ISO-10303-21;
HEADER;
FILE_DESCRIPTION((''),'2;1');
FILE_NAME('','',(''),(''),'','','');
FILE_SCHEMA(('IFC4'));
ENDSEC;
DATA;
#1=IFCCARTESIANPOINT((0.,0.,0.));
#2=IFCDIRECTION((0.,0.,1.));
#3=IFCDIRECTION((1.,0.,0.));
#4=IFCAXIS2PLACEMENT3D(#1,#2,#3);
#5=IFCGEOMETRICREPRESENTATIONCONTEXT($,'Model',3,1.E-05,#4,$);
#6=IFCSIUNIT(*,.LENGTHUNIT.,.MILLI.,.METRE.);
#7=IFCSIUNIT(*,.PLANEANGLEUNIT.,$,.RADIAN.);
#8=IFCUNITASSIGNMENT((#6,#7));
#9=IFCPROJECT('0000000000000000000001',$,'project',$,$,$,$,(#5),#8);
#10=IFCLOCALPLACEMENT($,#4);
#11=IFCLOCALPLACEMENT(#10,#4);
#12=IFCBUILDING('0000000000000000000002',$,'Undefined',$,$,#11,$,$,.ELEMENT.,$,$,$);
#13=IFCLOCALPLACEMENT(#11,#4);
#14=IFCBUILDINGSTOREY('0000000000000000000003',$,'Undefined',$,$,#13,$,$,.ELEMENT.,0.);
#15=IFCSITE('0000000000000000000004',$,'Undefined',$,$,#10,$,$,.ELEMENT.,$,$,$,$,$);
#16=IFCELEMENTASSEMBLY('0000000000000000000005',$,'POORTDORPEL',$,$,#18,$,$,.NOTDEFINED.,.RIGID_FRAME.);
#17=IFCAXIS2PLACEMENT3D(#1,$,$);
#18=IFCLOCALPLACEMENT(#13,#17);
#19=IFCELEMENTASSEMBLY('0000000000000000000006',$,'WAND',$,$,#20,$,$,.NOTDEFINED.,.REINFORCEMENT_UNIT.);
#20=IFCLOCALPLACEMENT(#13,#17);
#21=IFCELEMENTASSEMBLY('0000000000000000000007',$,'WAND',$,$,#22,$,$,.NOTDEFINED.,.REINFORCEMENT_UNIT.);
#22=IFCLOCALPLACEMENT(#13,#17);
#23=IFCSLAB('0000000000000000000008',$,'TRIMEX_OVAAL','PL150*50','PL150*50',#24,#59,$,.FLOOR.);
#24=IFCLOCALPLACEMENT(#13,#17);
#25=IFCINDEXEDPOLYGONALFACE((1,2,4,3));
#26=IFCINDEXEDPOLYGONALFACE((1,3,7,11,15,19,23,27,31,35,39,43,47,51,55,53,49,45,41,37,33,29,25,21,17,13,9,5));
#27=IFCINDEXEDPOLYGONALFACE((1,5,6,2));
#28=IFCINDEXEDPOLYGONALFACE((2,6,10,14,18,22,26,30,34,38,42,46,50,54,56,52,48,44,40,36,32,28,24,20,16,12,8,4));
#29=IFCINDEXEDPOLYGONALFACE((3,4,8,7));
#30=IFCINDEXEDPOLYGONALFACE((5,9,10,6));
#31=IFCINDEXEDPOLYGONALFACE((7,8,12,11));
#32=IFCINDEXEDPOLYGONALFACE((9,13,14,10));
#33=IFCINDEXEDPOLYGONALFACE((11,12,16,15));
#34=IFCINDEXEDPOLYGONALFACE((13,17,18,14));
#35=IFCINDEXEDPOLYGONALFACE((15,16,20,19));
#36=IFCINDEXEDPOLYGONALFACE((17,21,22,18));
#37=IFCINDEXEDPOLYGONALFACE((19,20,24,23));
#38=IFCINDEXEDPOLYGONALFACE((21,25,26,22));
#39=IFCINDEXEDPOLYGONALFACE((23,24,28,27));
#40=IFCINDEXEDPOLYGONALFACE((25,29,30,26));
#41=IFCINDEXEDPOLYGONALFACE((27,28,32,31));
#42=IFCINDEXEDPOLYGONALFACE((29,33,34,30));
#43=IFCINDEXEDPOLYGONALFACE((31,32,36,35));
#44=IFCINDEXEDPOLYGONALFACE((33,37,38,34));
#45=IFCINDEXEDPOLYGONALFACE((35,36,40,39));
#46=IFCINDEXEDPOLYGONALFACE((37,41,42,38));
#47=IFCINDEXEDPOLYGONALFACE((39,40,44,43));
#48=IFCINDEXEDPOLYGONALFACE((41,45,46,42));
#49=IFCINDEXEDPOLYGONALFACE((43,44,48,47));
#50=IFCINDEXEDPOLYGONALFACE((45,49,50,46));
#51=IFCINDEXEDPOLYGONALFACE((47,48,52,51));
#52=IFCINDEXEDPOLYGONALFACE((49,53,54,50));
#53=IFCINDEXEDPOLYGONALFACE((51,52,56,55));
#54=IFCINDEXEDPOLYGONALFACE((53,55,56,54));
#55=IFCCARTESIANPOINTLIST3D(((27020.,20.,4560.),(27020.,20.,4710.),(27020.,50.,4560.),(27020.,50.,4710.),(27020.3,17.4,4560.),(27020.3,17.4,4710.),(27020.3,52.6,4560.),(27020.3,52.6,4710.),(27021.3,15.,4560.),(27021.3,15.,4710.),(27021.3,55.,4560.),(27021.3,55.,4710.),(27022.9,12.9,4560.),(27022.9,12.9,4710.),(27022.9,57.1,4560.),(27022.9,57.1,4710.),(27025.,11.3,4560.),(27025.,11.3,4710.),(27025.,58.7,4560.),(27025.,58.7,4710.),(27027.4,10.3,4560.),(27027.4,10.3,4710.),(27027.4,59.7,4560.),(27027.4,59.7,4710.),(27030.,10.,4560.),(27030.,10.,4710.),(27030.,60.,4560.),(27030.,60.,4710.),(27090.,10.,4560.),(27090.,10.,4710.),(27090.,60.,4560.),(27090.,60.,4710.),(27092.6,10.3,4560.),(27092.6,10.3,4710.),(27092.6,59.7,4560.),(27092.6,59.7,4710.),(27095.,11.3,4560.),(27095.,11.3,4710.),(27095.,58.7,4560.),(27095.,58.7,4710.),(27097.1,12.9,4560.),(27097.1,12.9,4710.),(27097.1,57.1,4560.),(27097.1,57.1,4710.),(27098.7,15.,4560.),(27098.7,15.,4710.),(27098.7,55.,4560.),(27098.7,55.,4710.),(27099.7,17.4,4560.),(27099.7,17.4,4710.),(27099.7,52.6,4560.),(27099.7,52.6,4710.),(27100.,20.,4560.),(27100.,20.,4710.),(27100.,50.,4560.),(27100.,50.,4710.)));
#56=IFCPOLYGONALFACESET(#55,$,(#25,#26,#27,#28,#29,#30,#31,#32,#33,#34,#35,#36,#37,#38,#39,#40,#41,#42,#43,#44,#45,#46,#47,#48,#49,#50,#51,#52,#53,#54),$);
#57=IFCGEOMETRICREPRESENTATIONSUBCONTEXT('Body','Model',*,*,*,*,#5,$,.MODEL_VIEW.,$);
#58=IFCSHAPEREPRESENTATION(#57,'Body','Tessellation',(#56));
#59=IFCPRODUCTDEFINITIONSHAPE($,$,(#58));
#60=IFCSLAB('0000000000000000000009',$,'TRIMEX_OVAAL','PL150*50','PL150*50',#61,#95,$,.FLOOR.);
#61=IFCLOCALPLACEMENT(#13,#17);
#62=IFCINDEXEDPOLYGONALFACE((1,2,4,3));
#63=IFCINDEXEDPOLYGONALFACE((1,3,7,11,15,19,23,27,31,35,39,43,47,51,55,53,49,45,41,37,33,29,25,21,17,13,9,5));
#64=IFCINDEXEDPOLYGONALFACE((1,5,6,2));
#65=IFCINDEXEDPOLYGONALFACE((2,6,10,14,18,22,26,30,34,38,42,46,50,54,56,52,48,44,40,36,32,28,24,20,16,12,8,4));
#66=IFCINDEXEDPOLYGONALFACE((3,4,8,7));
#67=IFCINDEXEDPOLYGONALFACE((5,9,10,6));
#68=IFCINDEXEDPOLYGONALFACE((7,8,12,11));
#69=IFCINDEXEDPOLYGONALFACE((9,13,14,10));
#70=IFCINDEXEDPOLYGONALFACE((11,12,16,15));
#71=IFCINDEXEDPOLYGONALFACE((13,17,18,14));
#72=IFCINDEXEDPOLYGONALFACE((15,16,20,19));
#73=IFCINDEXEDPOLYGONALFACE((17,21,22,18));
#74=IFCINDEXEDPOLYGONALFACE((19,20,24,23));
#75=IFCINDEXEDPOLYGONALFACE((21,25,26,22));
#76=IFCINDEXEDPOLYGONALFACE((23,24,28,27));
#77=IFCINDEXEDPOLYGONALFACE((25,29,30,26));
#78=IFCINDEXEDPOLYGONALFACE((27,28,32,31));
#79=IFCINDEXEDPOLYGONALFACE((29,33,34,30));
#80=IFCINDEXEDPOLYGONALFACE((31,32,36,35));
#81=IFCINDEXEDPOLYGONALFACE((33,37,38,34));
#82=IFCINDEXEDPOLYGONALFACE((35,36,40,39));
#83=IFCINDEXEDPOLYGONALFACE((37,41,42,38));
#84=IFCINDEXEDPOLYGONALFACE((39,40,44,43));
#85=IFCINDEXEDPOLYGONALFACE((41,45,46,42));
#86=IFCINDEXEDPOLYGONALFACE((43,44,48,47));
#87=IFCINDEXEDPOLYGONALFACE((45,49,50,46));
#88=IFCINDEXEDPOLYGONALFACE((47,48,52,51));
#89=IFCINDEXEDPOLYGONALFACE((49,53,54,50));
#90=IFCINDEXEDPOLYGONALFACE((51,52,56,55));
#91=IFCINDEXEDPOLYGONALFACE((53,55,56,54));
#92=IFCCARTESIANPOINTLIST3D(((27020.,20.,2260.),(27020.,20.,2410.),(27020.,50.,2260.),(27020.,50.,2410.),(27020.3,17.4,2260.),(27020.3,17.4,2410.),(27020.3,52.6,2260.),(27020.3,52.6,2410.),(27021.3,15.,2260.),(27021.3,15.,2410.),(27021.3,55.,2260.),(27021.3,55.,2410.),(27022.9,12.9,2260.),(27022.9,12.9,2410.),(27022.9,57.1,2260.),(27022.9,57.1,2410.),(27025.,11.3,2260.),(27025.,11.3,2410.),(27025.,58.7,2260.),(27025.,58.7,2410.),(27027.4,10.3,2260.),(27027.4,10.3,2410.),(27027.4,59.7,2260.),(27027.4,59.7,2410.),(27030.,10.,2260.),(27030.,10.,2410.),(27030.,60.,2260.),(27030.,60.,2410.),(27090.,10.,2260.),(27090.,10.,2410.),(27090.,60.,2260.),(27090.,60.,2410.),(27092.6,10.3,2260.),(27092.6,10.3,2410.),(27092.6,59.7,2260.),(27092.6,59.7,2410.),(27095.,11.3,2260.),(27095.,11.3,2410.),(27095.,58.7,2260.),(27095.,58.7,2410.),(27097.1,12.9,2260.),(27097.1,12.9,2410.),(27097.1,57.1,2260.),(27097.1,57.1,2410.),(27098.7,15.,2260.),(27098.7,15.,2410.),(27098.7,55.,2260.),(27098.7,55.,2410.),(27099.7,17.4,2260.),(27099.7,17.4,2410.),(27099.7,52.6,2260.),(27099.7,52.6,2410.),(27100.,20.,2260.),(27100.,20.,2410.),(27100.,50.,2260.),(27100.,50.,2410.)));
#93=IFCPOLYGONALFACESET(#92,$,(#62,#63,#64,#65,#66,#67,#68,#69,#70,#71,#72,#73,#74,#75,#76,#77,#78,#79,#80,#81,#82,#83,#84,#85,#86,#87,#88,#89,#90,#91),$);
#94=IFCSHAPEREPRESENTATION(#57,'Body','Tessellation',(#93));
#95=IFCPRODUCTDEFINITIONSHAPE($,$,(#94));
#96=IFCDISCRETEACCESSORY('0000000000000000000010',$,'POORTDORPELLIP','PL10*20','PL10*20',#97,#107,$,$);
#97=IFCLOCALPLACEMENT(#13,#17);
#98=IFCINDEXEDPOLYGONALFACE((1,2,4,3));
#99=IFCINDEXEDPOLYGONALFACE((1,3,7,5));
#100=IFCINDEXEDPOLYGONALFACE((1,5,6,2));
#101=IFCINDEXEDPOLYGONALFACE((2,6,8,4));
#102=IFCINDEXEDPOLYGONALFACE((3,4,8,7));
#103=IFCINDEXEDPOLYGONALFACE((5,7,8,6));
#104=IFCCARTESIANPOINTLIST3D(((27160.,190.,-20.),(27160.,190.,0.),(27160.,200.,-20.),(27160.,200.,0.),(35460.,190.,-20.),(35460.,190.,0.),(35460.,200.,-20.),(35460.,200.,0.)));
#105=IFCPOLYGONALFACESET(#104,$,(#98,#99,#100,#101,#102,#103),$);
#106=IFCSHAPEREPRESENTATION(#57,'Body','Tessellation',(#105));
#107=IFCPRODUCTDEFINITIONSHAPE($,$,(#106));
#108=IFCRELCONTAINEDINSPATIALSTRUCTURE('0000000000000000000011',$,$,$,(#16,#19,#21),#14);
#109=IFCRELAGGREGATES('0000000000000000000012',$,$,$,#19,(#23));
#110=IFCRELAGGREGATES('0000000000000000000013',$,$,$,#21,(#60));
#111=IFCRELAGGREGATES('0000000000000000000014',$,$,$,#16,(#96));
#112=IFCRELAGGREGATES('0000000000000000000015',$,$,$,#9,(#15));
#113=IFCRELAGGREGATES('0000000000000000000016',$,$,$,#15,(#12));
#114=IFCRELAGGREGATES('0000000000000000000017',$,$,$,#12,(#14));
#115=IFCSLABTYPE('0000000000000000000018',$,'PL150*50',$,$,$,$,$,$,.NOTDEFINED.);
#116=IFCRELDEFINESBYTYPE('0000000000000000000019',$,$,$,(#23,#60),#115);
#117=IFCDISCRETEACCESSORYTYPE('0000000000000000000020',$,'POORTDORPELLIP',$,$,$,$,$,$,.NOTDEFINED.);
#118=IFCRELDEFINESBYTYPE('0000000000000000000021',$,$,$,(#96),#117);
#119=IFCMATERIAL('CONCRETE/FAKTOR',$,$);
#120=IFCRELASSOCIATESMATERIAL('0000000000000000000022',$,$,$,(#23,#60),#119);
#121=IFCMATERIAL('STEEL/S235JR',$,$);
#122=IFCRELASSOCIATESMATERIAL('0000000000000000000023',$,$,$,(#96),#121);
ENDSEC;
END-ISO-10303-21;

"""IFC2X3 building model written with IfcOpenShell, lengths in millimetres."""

from ifc_helpers import new_model, si_unit, frame, frame_2d, origin_with_axes, place, context, subcontext, project, spatial, polyline, circle_curve, parameter, trimmed, segment, composite_curve, rectangle, outline, extrude, material, type_object, element, aggregate, save


model = new_model("IFC2X3")

# Units and contexts
model_context = context("Model", 3, precision=1e-05, world=origin_with_axes())
body_context = subcontext(model_context, "Body", "Model", "MODEL_VIEW")
ifc_project = project(units=[si_unit("LENGTHUNIT", "METRE", prefix="MILLI"), si_unit("PLANEANGLEUNIT", "RADIAN")], contexts=[model_context])

# Site, building, storey
site_placement = place(None, origin_with_axes())
site = spatial("IfcSite", under=ifc_project, at=site_placement, Name="Undefined", CompositionType="ELEMENT")
building_placement = place(site_placement, origin_with_axes())
building = spatial("IfcBuilding", under=site, at=building_placement, Name="Undefined", CompositionType="ELEMENT")
storey_placement = place(building_placement, origin_with_axes())
storey = spatial("IfcBuildingStorey", under=building, at=storey_placement, Name="Undefined", CompositionType="ELEMENT", Elevation=0.0)

# Element assembly
assembly_1_placement = place(storey_placement, origin_with_axes())
assembly_1 = element("IfcElementAssembly", 1, at=assembly_1_placement, inside=storey, Name="POORTDORPEL", AssemblyPlace="NOTDEFINED", PredefinedType="RIGID_FRAME")
ifc_material_1 = material(Name="STEEL/S235JR")

# Element assemblies
assembly_2_placement = place(storey_placement, origin_with_axes())
assembly_2 = element("IfcElementAssembly", 2, at=assembly_2_placement, inside=storey, Name="WAND", AssemblyPlace="NOTDEFINED", PredefinedType="REINFORCEMENT_UNIT")
assembly_3_placement = place(storey_placement, origin_with_axes())
assembly_3 = element("IfcElementAssembly", 3, at=assembly_3_placement, inside=storey, Name="WAND", AssemblyPlace="NOTDEFINED", PredefinedType="REINFORCEMENT_UNIT")
ifc_material_2 = material(Name="CONCRETE/FAKTOR")

# Slabs
slab_type = type_object("IfcSlabType", Name="PL150*50", PredefinedType="NOTDEFINED")
slab_1_placement = place(assembly_2_placement, frame((27020.0, 60.0, 4635.0), z_axis=(0.0, 0.0, 1.0), x_axis=(0.0, -1.0, 0.0)))
slab_1 = element("IfcSlab", 4, at=slab_1_placement, type_object=slab_type, material=ifc_material_2, Name="TRIMEX_OVAAL", Description="PL150*50", ObjectType="PL150*50", PredefinedType="FLOOR", context=body_context, shape_type="SweptSolid", body=[
    extrude(outline(composite_curve([segment(trimmed(circle_curve(frame_2d((10.0, 10.0), x_axis=(-1.0, 0.0)), 10.0), [parameter(0.0)], [parameter(1.570796)], True, "PARAMETER"), True, "CONTINUOUS"), segment(polyline([(10.0, 0.0), (40.0, 0.0)]), True, "CONTINUOUS"), segment(trimmed(circle_curve(frame_2d((40.0, 10.0), x_axis=(0.0, -1.0)), 10.0), [parameter(0.0)], [parameter(1.570796)], True, "PARAMETER"), True, "CONTINUOUS"), segment(polyline([(50.0, 10.0), (50.0, 70.0)]), True, "CONTINUOUS"), segment(trimmed(circle_curve(frame_2d((40.0, 70.0), x_axis=(1.0, 0.0)), 10.0), [parameter(0.0)], [parameter(1.570796)], True, "PARAMETER"), True, "CONTINUOUS"), segment(polyline([(40.0, 80.0), (10.0, 80.0)]), True, "CONTINUOUS"), segment(trimmed(circle_curve(frame_2d((10.0, 70.0), x_axis=(0.0, 1.0)), 10.0), [parameter(0.0)], [parameter(1.570796)], True, "PARAMETER"), True, "CONTINUOUS"), segment(polyline([(0.0, 70.0), (0.0, 10.0)]), True, "CONTINUOUS")], self_intersect=True)), frame((0.0, 0.0, -75.0), z_axis=(0.0, 0.0, 1.0), x_axis=(1.0, 0.0, 0.0)), (0.0, 0.0, 1.0), 150.0),
])
aggregate(assembly_2, [slab_1])
slab_2_placement = place(assembly_3_placement, frame((27020.0, 60.0, 2335.0), z_axis=(0.0, 0.0, 1.0), x_axis=(0.0, -1.0, 0.0)))
slab_2 = element("IfcSlab", 5, at=slab_2_placement, type_object=slab_type, material=ifc_material_2, Name="TRIMEX_OVAAL", Description="PL150*50", ObjectType="PL150*50", PredefinedType="FLOOR", context=body_context, shape_type="SweptSolid", body=[
    extrude(outline(composite_curve([segment(trimmed(circle_curve(frame_2d((10.0, 10.0), x_axis=(-1.0, 0.0)), 10.0), [parameter(0.0)], [parameter(1.570796)], True, "PARAMETER"), True, "CONTINUOUS"), segment(polyline([(10.0, 0.0), (40.0, 0.0)]), True, "CONTINUOUS"), segment(trimmed(circle_curve(frame_2d((40.0, 10.0), x_axis=(0.0, -1.0)), 10.0), [parameter(0.0)], [parameter(1.570796)], True, "PARAMETER"), True, "CONTINUOUS"), segment(polyline([(50.0, 10.0), (50.0, 70.0)]), True, "CONTINUOUS"), segment(trimmed(circle_curve(frame_2d((40.0, 70.0), x_axis=(1.0, 0.0)), 10.0), [parameter(0.0)], [parameter(1.570796)], True, "PARAMETER"), True, "CONTINUOUS"), segment(polyline([(40.0, 80.0), (10.0, 80.0)]), True, "CONTINUOUS"), segment(trimmed(circle_curve(frame_2d((10.0, 70.0), x_axis=(0.0, 1.0)), 10.0), [parameter(0.0)], [parameter(1.570796)], True, "PARAMETER"), True, "CONTINUOUS"), segment(polyline([(0.0, 70.0), (0.0, 10.0)]), True, "CONTINUOUS")], self_intersect=True)), frame((0.0, 0.0, -75.0), z_axis=(0.0, 0.0, 1.0), x_axis=(1.0, 0.0, 0.0)), (0.0, 0.0, 1.0), 150.0),
])
aggregate(assembly_3, [slab_2])

# Discrete accessory
discrete_accessory_type = type_object("IfcDiscreteAccessoryType", Name="POORTDORPELLIP")
discrete_accessory_placement = place(assembly_1_placement, frame((27160.0, 195.0, -10.0), z_axis=(0.0, 0.0, -1.0), x_axis=(1.0, 0.0, 0.0)))
discrete_accessory = element("IfcDiscreteAccessory", 6, at=discrete_accessory_placement, type_object=discrete_accessory_type, material=ifc_material_1, Name="POORTDORPELLIP", Description="PL10*20", ObjectType="PL10*20", context=body_context, shape_type="SweptSolid", body=[
    extrude(rectangle(XDim=10.0, YDim=20.0, at=frame_2d((0.0, 0.0), x_axis=(1.0, 0.0))), frame((8300.0, 0.0, 0.0), z_axis=(-1.0, 0.0, 0.0), x_axis=(0.0, -1.0, 0.0)), (0.0, 0.0, 1.0), 8300.0),
])
aggregate(assembly_1, [discrete_accessory])

save(model, "model.ifc")
